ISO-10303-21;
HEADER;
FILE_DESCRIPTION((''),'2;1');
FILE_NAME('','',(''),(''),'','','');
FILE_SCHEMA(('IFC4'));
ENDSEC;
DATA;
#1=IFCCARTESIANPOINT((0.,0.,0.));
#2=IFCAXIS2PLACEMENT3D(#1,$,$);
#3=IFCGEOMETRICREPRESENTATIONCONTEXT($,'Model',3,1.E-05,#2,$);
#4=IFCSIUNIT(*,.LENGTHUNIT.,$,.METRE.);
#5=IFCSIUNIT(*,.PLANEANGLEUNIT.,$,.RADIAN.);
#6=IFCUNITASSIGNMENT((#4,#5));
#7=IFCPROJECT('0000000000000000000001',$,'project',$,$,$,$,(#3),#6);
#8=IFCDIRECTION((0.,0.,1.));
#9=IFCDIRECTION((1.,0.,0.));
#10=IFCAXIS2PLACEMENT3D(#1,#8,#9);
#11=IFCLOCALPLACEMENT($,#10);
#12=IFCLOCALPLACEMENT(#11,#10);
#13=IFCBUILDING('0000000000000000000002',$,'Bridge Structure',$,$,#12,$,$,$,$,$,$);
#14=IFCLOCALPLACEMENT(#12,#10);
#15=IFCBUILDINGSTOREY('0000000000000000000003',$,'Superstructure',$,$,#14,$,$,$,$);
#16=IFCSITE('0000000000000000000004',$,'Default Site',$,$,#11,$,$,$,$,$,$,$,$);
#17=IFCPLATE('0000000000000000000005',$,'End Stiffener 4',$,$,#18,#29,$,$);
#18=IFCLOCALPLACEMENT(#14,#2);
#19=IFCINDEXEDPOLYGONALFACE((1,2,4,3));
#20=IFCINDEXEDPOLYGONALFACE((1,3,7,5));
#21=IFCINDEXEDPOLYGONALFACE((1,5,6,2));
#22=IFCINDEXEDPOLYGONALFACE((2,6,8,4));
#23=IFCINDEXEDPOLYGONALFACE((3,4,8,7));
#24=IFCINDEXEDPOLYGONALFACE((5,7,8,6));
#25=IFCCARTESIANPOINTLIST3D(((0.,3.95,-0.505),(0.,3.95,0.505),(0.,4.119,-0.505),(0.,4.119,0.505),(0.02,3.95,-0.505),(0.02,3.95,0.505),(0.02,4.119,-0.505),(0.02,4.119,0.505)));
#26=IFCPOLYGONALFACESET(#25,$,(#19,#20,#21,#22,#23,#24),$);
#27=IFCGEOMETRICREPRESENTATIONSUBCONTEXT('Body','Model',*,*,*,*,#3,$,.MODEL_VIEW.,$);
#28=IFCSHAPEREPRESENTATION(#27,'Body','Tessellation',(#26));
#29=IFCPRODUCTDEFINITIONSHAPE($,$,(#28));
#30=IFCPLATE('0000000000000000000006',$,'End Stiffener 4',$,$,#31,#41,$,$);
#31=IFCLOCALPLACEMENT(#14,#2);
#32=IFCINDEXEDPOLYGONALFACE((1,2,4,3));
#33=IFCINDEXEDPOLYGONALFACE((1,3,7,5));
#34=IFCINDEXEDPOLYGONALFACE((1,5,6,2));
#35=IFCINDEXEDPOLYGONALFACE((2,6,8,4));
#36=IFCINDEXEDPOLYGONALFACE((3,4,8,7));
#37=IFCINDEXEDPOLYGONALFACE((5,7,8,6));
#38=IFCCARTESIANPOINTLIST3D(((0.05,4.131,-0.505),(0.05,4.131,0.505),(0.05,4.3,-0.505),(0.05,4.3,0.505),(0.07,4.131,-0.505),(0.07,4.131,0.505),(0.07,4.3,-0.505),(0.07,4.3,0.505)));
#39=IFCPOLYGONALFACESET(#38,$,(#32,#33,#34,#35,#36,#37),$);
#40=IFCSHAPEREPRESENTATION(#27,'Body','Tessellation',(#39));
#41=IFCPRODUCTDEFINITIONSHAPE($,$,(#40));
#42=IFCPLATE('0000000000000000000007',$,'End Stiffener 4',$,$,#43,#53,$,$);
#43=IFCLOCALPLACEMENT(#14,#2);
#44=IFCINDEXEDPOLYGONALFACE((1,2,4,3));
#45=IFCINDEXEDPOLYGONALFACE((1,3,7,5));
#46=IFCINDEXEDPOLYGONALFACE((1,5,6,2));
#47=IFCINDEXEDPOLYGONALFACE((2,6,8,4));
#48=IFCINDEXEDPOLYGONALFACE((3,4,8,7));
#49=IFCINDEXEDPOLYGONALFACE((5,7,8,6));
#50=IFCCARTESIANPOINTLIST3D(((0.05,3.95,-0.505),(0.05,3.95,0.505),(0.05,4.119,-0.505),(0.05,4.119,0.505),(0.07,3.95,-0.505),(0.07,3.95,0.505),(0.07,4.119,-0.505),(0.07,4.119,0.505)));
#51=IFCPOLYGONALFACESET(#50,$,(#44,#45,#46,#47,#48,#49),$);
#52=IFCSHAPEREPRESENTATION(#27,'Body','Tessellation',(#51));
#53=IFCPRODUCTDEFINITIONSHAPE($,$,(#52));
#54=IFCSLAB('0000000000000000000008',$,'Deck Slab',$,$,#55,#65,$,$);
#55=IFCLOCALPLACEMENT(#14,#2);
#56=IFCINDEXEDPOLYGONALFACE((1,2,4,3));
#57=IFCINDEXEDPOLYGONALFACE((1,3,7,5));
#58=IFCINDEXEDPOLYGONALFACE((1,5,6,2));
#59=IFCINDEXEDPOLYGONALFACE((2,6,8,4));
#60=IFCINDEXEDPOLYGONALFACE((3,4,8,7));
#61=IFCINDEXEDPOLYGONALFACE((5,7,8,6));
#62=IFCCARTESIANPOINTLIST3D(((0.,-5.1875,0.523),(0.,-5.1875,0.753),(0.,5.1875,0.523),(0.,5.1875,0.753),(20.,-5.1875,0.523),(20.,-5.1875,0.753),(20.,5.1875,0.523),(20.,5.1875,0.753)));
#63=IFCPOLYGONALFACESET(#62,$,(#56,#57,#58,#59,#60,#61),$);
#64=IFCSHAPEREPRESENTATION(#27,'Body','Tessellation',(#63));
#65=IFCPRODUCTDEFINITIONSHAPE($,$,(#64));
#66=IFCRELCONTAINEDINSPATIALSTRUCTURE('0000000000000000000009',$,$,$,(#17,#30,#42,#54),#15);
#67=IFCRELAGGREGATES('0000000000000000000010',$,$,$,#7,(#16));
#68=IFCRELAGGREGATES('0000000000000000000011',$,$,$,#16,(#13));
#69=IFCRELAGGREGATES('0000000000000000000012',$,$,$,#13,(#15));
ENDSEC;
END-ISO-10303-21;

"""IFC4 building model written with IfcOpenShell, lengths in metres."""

from ifc_helpers import new_model, si_unit, frame, origin, origin_with_axes, origin_2d_with_axis, place, context, subcontext, project, spatial, polyline, rectangle, outline, extrude, element, save


model = new_model("IFC4")

# Units and contexts
model_context = context("Model", 3, precision=1e-05, world=origin())
body_context = subcontext(model_context, "Body", "Model", "MODEL_VIEW")
ifc_project = project(units=[si_unit("LENGTHUNIT", "METRE"), si_unit("PLANEANGLEUNIT", "RADIAN")], contexts=[model_context])

# Site, building, storey
site_placement = place(None, origin_with_axes())
site = spatial("IfcSite", under=ifc_project, at=site_placement, Name="Default Site")
building_placement = place(site_placement, origin_with_axes())
building = spatial("IfcBuilding", under=site, at=building_placement, Name="Bridge Structure")
storey_placement = place(building_placement, origin_with_axes())
storey = spatial("IfcBuildingStorey", under=building, at=storey_placement, Name="Superstructure")

# Plates
for number, where, z_axis, x_axis, name in (
    (1, (0.01, 4.0345, -0.505), (0.0, 0.0, 1.0), (1.0, 0.0, 0.0), "End Stiffener 4"),
    (2, (0.06, 4.2155, -0.505), (0.0, 0.0, 1.0), (1.0, 0.0, 0.0), "End Stiffener 4"),
    (3, (0.06, 4.0345, -0.505), (0.0, 0.0, 1.0), (1.0, 0.0, 0.0), "End Stiffener 4"),
):
    element("IfcPlate", number, at=place(storey_placement, frame(where, z_axis=z_axis, x_axis=x_axis)), inside=storey, Name=name, context=body_context, shape_type="SweptSolid", body=[
        extrude(rectangle(XDim=0.02, YDim=0.169, at=origin_2d_with_axis()), origin_with_axes(), (0.0, 0.0, 1.0), 1.01),
    ])

# Slab
slab_placement = place(storey_placement, frame((0.0, 0.0, 0.523), z_axis=(0.0, 0.0, 1.0), x_axis=(1.0, 0.0, 0.0)))
element("IfcSlab", 4, at=slab_placement, inside=storey, Name="Deck Slab", context=body_context, shape_type="SweptSolid", body=[
    extrude(outline(polyline([(0.0, -5.1875), (20.0, -5.1875), (20.0, 5.1875), (0.0, 5.1875), (0.0, -5.1875)])), origin_with_axes(), (0.0, 0.0, 1.0), 0.23),
])

save(model, "model.ifc")
